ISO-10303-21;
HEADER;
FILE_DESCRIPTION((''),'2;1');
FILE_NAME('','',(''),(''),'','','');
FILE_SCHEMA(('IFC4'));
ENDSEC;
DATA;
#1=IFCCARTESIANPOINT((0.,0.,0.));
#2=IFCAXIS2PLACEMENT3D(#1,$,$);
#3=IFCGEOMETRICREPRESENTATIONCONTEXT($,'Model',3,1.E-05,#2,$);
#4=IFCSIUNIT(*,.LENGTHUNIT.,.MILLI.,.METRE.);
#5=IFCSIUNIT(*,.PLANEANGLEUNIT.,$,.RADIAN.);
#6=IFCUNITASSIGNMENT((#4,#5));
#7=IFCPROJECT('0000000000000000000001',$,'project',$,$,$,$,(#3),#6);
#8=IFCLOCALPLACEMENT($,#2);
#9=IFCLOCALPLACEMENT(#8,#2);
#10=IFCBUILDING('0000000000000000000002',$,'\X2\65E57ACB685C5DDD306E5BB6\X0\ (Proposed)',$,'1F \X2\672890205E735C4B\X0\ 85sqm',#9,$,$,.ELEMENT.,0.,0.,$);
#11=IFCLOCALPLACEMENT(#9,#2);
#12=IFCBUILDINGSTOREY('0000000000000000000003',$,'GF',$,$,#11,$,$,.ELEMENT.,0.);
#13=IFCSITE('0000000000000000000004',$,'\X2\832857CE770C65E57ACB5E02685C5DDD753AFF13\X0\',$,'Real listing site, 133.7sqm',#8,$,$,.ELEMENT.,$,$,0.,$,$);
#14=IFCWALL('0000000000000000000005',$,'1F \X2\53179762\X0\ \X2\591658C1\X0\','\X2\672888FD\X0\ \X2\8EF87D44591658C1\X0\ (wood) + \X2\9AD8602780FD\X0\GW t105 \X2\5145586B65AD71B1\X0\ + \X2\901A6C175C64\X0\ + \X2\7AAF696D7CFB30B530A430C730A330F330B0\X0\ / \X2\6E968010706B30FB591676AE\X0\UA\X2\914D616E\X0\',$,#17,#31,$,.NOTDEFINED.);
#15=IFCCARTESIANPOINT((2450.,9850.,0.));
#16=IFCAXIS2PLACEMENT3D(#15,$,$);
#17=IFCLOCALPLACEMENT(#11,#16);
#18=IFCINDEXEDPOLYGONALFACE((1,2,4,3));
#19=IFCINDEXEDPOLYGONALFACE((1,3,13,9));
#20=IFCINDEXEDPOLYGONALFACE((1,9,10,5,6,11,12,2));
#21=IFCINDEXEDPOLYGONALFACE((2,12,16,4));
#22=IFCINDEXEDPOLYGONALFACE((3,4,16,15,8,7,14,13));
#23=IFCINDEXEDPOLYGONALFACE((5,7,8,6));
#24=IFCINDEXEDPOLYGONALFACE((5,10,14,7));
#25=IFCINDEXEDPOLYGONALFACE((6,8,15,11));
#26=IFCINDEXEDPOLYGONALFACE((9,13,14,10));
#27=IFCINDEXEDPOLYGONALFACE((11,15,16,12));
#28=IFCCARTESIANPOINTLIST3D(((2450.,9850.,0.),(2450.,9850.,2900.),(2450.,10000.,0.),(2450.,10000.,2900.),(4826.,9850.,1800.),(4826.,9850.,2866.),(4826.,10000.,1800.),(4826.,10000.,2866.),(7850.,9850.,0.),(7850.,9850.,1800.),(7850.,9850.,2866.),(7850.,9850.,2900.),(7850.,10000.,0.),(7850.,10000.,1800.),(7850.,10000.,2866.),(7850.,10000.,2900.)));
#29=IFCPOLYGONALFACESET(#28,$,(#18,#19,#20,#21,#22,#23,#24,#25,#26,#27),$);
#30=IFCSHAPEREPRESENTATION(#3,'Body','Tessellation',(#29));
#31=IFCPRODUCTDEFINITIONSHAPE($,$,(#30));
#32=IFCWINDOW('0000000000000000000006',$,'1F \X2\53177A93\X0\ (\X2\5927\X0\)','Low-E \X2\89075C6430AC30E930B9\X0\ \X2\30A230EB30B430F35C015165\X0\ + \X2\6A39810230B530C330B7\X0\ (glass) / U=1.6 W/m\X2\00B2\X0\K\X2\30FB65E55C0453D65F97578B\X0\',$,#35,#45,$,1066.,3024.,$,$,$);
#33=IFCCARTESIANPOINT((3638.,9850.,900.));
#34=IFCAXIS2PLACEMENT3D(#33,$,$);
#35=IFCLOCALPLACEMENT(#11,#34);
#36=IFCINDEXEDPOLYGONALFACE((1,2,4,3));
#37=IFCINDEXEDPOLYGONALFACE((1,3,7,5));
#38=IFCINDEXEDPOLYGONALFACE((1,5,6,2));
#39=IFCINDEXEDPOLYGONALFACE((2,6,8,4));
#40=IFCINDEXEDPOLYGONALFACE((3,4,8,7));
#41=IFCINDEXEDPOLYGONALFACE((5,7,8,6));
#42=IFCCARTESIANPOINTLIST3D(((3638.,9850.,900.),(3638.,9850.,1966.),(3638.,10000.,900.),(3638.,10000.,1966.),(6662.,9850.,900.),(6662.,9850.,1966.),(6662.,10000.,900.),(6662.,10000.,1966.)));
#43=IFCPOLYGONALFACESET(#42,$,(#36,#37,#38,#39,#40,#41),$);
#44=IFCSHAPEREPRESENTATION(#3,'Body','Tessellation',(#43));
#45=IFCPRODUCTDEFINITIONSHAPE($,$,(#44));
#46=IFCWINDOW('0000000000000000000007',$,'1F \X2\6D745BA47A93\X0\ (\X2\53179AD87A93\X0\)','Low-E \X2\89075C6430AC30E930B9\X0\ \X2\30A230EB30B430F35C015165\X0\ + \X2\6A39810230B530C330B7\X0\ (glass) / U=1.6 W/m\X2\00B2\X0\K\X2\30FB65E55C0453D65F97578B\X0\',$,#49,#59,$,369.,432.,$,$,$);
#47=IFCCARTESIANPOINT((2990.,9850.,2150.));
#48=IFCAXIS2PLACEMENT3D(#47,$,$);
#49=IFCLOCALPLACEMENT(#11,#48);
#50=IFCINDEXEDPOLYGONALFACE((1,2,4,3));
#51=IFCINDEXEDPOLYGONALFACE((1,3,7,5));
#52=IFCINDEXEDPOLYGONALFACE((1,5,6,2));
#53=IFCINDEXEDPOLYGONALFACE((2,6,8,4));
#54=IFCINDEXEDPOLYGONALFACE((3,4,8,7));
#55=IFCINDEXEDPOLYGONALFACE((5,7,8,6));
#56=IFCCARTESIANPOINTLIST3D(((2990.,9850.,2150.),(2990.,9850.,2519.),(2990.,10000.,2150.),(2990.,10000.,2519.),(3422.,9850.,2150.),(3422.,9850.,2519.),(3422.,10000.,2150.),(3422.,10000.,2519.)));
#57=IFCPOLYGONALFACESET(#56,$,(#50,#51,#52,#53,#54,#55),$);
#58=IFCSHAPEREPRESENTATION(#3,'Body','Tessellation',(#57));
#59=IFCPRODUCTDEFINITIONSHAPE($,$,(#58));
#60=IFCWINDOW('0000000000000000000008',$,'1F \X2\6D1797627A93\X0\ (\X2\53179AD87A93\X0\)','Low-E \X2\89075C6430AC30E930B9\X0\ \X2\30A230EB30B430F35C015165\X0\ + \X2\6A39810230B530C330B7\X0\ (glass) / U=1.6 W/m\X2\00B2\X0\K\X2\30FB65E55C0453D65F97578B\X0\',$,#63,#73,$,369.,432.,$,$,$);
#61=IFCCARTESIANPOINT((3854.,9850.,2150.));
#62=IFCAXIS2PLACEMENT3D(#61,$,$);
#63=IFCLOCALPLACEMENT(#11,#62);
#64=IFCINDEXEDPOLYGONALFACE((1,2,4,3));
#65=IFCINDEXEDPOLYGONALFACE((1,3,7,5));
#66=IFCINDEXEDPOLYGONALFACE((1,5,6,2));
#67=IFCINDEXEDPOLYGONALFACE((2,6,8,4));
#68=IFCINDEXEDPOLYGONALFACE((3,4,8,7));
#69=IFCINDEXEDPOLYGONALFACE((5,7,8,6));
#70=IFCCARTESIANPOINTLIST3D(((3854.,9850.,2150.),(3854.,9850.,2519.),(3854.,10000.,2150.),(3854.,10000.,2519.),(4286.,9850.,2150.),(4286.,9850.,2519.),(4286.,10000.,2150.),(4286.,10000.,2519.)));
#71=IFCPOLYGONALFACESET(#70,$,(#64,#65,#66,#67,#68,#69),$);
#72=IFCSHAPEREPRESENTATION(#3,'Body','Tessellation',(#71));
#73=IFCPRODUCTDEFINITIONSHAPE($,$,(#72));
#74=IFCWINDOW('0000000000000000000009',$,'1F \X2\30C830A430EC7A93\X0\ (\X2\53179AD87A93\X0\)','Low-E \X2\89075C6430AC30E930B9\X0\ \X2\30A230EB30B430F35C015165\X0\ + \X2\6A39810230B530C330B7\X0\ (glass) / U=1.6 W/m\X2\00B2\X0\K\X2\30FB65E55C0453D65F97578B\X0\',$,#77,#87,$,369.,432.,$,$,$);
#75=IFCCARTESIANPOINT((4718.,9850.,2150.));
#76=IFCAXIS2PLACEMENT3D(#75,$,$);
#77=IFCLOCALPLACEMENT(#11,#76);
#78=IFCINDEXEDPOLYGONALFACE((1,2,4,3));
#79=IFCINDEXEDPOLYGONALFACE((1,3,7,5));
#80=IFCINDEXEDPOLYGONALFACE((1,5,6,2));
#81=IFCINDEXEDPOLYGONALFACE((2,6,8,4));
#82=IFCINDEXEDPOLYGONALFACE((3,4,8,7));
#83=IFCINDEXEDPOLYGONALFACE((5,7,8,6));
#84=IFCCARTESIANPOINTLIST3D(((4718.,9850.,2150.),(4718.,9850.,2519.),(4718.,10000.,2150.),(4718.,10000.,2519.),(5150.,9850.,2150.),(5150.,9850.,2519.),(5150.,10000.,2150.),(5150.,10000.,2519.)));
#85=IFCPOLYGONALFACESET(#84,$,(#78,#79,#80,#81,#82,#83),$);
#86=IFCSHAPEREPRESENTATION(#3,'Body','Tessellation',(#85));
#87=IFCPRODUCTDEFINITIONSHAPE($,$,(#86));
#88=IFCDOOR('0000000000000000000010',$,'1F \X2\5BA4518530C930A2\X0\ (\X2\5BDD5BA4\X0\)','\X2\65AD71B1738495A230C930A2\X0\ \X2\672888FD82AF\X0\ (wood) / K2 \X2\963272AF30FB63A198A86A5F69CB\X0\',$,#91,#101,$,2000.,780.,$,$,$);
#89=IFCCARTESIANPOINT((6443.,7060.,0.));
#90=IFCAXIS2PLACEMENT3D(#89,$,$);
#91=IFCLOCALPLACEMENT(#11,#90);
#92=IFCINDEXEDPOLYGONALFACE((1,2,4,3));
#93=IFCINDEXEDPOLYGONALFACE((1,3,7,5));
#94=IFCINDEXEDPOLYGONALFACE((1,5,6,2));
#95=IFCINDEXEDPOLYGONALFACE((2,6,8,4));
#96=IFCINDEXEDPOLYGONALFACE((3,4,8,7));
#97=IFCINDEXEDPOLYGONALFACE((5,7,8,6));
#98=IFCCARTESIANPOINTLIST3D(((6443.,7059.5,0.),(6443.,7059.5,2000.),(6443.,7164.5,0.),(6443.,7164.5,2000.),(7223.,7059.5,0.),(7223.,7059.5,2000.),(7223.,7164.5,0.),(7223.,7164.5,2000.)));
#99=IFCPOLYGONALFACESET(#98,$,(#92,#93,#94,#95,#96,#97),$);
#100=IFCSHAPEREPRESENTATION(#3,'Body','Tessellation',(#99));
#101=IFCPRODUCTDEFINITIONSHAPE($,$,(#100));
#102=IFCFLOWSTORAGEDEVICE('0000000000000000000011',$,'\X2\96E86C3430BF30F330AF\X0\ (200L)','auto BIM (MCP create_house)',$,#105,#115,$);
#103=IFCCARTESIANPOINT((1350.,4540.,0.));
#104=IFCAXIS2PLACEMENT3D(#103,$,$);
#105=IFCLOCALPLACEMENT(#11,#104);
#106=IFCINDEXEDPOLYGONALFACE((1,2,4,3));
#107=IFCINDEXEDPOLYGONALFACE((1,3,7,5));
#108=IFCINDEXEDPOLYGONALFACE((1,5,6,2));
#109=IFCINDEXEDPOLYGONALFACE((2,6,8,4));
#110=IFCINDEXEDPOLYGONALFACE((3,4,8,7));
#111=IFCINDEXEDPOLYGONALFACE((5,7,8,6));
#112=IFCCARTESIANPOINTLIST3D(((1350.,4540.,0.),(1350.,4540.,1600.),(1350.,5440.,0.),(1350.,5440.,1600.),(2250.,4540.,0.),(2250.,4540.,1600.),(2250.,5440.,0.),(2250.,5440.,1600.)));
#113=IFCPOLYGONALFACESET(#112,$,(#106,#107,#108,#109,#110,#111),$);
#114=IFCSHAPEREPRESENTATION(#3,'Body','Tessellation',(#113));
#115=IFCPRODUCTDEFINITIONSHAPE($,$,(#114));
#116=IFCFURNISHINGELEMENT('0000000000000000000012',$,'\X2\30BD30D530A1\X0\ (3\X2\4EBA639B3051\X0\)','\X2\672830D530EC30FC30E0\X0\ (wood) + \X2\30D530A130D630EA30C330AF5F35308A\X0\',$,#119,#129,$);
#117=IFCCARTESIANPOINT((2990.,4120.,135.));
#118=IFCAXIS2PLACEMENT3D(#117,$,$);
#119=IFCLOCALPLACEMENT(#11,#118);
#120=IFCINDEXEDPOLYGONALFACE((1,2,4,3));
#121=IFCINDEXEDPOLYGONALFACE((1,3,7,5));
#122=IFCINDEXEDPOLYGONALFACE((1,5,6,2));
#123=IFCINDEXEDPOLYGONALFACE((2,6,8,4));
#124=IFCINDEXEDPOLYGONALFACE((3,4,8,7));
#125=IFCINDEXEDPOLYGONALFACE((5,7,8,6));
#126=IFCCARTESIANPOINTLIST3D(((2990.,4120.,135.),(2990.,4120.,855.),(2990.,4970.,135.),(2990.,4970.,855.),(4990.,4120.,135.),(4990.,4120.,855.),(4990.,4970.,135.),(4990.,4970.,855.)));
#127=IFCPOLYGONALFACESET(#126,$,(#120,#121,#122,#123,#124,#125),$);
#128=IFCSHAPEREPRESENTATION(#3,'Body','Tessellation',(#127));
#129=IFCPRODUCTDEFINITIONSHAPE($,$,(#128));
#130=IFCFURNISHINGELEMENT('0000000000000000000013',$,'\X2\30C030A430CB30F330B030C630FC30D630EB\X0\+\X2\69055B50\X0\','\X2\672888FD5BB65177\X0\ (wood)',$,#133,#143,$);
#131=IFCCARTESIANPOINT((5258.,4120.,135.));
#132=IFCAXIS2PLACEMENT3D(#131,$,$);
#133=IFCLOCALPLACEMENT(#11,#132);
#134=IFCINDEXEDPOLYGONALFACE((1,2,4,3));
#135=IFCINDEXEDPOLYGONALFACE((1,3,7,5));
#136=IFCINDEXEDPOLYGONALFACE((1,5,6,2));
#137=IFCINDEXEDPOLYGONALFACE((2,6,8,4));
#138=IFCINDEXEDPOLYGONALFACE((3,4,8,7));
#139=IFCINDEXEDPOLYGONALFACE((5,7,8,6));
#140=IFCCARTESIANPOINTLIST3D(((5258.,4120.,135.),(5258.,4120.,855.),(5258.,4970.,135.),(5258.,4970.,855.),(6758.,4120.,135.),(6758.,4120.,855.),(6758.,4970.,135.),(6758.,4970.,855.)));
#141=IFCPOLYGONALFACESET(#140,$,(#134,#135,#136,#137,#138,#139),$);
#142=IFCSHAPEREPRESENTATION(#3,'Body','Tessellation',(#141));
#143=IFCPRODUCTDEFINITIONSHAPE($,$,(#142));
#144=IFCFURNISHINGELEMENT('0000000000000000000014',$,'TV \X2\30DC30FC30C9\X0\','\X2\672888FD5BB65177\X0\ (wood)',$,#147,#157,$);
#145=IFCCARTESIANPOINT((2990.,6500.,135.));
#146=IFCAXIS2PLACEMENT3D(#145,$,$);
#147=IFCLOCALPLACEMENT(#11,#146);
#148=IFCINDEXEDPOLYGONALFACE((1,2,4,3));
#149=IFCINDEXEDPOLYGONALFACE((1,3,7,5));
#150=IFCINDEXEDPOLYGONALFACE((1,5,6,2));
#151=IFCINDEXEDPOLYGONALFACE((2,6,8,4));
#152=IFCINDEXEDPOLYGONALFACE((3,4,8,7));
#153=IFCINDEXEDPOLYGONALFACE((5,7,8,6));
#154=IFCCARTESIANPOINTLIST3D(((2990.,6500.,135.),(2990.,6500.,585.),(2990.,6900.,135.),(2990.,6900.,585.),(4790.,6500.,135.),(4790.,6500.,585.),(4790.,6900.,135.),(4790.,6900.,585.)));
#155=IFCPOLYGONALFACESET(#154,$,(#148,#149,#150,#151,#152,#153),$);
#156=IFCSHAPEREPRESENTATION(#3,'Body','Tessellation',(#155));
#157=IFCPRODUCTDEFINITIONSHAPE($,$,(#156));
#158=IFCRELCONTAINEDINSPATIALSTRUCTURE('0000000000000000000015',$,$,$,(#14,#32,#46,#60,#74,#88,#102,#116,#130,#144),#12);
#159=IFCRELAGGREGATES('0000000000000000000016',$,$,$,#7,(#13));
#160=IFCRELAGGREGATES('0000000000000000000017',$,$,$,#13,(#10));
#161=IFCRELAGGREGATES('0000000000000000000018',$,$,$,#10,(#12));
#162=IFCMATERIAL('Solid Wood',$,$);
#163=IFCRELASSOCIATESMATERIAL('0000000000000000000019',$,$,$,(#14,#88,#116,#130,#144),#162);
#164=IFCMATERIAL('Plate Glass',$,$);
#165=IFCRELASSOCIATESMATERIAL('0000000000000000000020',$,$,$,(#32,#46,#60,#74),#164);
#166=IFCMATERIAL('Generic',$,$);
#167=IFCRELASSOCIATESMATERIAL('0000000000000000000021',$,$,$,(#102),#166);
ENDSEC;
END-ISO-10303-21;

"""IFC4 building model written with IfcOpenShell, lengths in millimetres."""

from ifc_helpers import new_model, si_unit, frame, frame_2d, origin, place, context, project, spatial, rectangle, extrude, material, element, fill, save


model = new_model("IFC4")

# Units and contexts
model_context = context("Model", 3, precision=1e-05, world=origin())
ifc_project = project(units=[si_unit("LENGTHUNIT", "METRE", prefix="MILLI"), si_unit("PLANEANGLEUNIT", "RADIAN")], contexts=[model_context])

# Site, building, storey
site_placement = place(None, origin())
site = spatial("IfcSite", under=ifc_project, at=site_placement, Name="茨城県日立市桜川町３", ObjectType="Real listing site, 133.7sqm", CompositionType="ELEMENT", RefElevation=0.0)
building_placement = place(site_placement, origin())
building = spatial("IfcBuilding", under=site, at=building_placement, Name="日立桜川の家 (Proposed)", ObjectType="1F 木造平屋 85sqm", CompositionType="ELEMENT", ElevationOfRefHeight=0.0, ElevationOfTerrain=0.0)
storey_placement = place(building_placement, origin())
storey = spatial("IfcBuildingStorey", under=building, at=storey_placement, Name="GF", CompositionType="ELEMENT", Elevation=0.0)

# Wall, openings, windows
ifc_material_1 = material(Name="Solid Wood")
wall_1_placement = place(storey_placement, frame((2450.0, 9850.0, 0.0)))
wall_1 = element("IfcWall", 1, at=wall_1_placement, inside=storey, material=ifc_material_1, Name="1F 北面 外壁", Description="木製 軸組外壁 (wood) + 高性能GW t105 充填断熱 + 通気層 + 窯業系サイディング / 準耐火・外皮UA配慮", PredefinedType="NOTDEFINED", context=model_context, shape_type="SweptSolid", body=[
    extrude(rectangle(XDim=5400.0, YDim=150.0, at=frame_2d((2700.0, 75.0))), frame((2450.0, 9850.0, 0.0)), (0.0, 0.0, 1.0), 2900.0),
])
opening_1_placement = place(storey_placement, frame((3638.0, 9850.0, 900.0)))
opening_1 = element("IfcOpeningElement", 2, at=opening_1_placement, cuts=wall_1, PredefinedType="NOTDEFINED", context=model_context, shape_type="SweptSolid", body=[
    extrude(rectangle(XDim=3024.0, YDim=150.0, at=frame_2d((1512.0, 75.0))), frame((3638.0, 9850.0, 900.0)), (0.0, 0.0, 1.0), 1066.0),
])
opening_2_placement = place(storey_placement, frame((2990.0, 9850.0, 2150.0)))
opening_2 = element("IfcOpeningElement", 3, at=opening_2_placement, cuts=wall_1, PredefinedType="NOTDEFINED", context=model_context, shape_type="SweptSolid", body=[
    extrude(rectangle(XDim=432.0, YDim=150.0, at=frame_2d((216.0, 75.0))), frame((2990.0, 9850.0, 2150.0)), (0.0, 0.0, 1.0), 369.0),
])
opening_3_placement = place(storey_placement, frame((3854.0, 9850.0, 2150.0)))
opening_3 = element("IfcOpeningElement", 4, at=opening_3_placement, cuts=wall_1, PredefinedType="NOTDEFINED", context=model_context, shape_type="SweptSolid", body=[
    extrude(rectangle(XDim=432.0, YDim=150.0, at=frame_2d((216.0, 75.0))), frame((3854.0, 9850.0, 2150.0)), (0.0, 0.0, 1.0), 369.0),
])
opening_4_placement = place(storey_placement, frame((4718.0, 9850.0, 2150.0)))
opening_4 = element("IfcOpeningElement", 5, at=opening_4_placement, cuts=wall_1, PredefinedType="NOTDEFINED", context=model_context, shape_type="SweptSolid", body=[
    extrude(rectangle(XDim=432.0, YDim=150.0, at=frame_2d((216.0, 75.0))), frame((4718.0, 9850.0, 2150.0)), (0.0, 0.0, 1.0), 369.0),
])
ifc_material_2 = material(Name="Plate Glass")
window_1_placement = place(storey_placement, frame((3638.0, 9850.0, 900.0)))
window_1 = element("IfcWindow", 6, at=window_1_placement, inside=storey, material=ifc_material_2, Name="1F 北窓 (大)", Description="Low-E 複層ガラス アルゴン封入 + 樹脂サッシ (glass) / U=1.6 W/m²K・日射取得型", OverallHeight=1066.0, OverallWidth=3024.0, context=model_context, shape_type="SweptSolid", body=[
    extrude(rectangle(XDim=3024.0, YDim=150.0, at=frame_2d((1512.0, 75.0))), frame((3638.0, 9850.0, 900.0)), (0.0, 0.0, 1.0), 1066.0),
])
fill(opening_1, window_1)
window_2_placement = place(storey_placement, frame((2990.0, 9850.0, 2150.0)))
window_2 = element("IfcWindow", 7, at=window_2_placement, inside=storey, material=ifc_material_2, Name="1F 浴室窓 (北高窓)", Description="Low-E 複層ガラス アルゴン封入 + 樹脂サッシ (glass) / U=1.6 W/m²K・日射取得型", OverallHeight=369.0, OverallWidth=432.0, context=model_context, shape_type="SweptSolid", body=[
    extrude(rectangle(XDim=432.0, YDim=150.0, at=frame_2d((216.0, 75.0))), frame((2990.0, 9850.0, 2150.0)), (0.0, 0.0, 1.0), 369.0),
])
fill(opening_2, window_2)
window_3_placement = place(storey_placement, frame((3854.0, 9850.0, 2150.0)))
window_3 = element("IfcWindow", 8, at=window_3_placement, inside=storey, material=ifc_material_2, Name="1F 洗面窓 (北高窓)", Description="Low-E 複層ガラス アルゴン封入 + 樹脂サッシ (glass) / U=1.6 W/m²K・日射取得型", OverallHeight=369.0, OverallWidth=432.0, context=model_context, shape_type="SweptSolid", body=[
    extrude(rectangle(XDim=432.0, YDim=150.0, at=frame_2d((216.0, 75.0))), frame((3854.0, 9850.0, 2150.0)), (0.0, 0.0, 1.0), 369.0),
])
fill(opening_3, window_3)
window_4_placement = place(storey_placement, frame((4718.0, 9850.0, 2150.0)))
window_4 = element("IfcWindow", 9, at=window_4_placement, inside=storey, material=ifc_material_2, Name="1F トイレ窓 (北高窓)", Description="Low-E 複層ガラス アルゴン封入 + 樹脂サッシ (glass) / U=1.6 W/m²K・日射取得型", OverallHeight=369.0, OverallWidth=432.0, context=model_context, shape_type="SweptSolid", body=[
    extrude(rectangle(XDim=432.0, YDim=150.0, at=frame_2d((216.0, 75.0))), frame((4718.0, 9850.0, 2150.0)), (0.0, 0.0, 1.0), 369.0),
])
fill(opening_4, window_4)

# Door
door_1_placement = place(storey_placement, frame((6443.0, 7060.0, 0.0)))
element("IfcDoor", 10, at=door_1_placement, inside=storey, material=ifc_material_1, Name="1F 室内ドア (寝室)", Description="断熱玄関ドア 木製芯 (wood) / K2 防犯・採風機構", OverallHeight=2000.0, OverallWidth=780.0, context=model_context, shape_type="SweptSolid", body=[
    extrude(rectangle(XDim=780.0, YDim=105.0, at=frame_2d((390.0, 52.0))), frame((6443.0, 7060.0, 0.0)), (0.0, 0.0, 1.0), 2000.0),
])

# Flow storage device
ifc_material_3 = material(Name="Generic")
flow_storage_device_placement = place(storey_placement, frame((1350.0, 4540.0, 0.0)))
element("IfcFlowStorageDevice", 11, at=flow_storage_device_placement, inside=storey, material=ifc_material_3, Name="雨水タンク (200L)", Description="auto BIM (MCP create_house)", context=model_context, shape_type="SweptSolid", body=[
    extrude(rectangle(XDim=900.0, YDim=900.0, at=frame_2d((450.0, 450.0))), frame((1350.0, 4540.0, 0.0)), (0.0, 0.0, 1.0), 1600.0),
])

# Furnishing elements
furnishing_1_placement = place(storey_placement, frame((2990.0, 4120.0, 135.0)))
element("IfcFurnishingElement", 12, at=furnishing_1_placement, inside=storey, material=ifc_material_1, Name="ソファ (3人掛け)", Description="木フレーム (wood) + ファブリック張り", context=model_context, shape_type="SweptSolid", body=[
    extrude(rectangle(XDim=2000.0, YDim=850.0, at=frame_2d((1000.0, 425.0))), frame((2990.0, 4120.0, 135.0)), (0.0, 0.0, 1.0), 720.0),
])
furnishing_2_placement = place(storey_placement, frame((5258.0, 4120.0, 135.0)))
element("IfcFurnishingElement", 13, at=furnishing_2_placement, inside=storey, material=ifc_material_1, Name="ダイニングテーブル+椅子", Description="木製家具 (wood)", context=model_context, shape_type="SweptSolid", body=[
    extrude(rectangle(XDim=1500.0, YDim=850.0, at=frame_2d((750.0, 425.0))), frame((5258.0, 4120.0, 135.0)), (0.0, 0.0, 1.0), 720.0),
])
furnishing_3_placement = place(storey_placement, frame((2990.0, 6500.0, 135.0)))
element("IfcFurnishingElement", 14, at=furnishing_3_placement, inside=storey, material=ifc_material_1, Name="TV ボード", Description="木製家具 (wood)", context=model_context, shape_type="SweptSolid", body=[
    extrude(rectangle(XDim=1800.0, YDim=400.0, at=frame_2d((900.0, 200.0))), frame((2990.0, 6500.0, 135.0)), (0.0, 0.0, 1.0), 450.0),
])

save(model, "model.ifc")
